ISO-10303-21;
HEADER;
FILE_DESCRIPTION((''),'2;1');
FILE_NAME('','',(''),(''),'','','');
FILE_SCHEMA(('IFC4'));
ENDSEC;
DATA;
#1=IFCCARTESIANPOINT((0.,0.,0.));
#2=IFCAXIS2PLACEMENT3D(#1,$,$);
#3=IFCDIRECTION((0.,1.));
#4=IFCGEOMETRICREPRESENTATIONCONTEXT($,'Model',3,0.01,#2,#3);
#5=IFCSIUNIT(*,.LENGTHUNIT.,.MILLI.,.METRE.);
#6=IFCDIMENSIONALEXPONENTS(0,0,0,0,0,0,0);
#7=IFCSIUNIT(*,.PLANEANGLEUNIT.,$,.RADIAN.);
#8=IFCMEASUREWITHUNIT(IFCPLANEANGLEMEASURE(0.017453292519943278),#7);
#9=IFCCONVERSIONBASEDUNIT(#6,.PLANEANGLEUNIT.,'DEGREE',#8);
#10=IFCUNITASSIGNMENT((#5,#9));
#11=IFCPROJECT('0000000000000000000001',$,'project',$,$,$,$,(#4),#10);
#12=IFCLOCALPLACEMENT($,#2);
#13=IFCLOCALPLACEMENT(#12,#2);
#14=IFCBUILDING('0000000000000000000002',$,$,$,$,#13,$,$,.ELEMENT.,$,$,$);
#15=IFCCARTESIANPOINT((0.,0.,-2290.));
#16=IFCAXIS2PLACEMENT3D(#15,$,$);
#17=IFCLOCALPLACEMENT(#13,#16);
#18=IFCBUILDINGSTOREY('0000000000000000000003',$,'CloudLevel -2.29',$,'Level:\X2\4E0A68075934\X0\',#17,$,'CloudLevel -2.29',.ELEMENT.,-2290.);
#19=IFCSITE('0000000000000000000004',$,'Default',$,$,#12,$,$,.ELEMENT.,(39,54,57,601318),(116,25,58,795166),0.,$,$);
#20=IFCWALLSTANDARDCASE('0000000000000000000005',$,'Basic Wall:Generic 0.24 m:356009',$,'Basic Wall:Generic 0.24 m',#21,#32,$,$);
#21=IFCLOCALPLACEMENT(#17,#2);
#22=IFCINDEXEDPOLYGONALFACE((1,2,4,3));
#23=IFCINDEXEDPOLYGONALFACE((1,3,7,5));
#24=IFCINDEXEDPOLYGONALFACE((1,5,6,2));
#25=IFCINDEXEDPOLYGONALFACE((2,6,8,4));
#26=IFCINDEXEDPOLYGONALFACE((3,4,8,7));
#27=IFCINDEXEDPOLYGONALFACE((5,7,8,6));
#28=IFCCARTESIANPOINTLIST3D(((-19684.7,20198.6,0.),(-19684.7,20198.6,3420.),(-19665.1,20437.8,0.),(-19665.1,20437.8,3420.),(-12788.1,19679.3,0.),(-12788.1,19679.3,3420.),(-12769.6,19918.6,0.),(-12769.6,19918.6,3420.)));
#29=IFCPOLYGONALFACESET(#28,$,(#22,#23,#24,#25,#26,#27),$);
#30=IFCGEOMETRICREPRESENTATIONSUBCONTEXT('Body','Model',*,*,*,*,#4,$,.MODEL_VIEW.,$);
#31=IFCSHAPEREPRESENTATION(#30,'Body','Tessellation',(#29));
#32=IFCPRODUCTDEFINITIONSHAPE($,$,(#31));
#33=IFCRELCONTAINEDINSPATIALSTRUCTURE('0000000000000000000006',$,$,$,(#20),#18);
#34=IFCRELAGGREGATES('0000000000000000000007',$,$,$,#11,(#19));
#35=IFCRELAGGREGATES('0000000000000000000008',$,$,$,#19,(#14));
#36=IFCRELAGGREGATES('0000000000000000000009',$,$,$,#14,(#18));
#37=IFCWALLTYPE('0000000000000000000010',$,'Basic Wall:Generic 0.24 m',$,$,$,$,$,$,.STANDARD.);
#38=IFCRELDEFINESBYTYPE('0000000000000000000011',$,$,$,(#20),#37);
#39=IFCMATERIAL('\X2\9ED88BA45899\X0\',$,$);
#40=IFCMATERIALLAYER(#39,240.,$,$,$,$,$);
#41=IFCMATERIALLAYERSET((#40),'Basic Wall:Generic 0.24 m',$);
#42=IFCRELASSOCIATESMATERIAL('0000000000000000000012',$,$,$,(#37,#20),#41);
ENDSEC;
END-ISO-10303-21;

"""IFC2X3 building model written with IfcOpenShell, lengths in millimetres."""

from ifc_helpers import new_model, entity, si_unit, converted_unit, direction, frame, origin, place, context, subcontext, project, spatial, polyline, outline, extrude, material, layer, layer_set, layer_usage, type_object, element, save


model = new_model("IFC2X3")

# Units and contexts
model_context = context("Model", 3, precision=0.01, world=origin(), true_north=direction((0.0, 1.0)))
body_context = subcontext(model_context, "Body", "Model", "MODEL_VIEW")
ifc_project = project(units=[si_unit("LENGTHUNIT", "METRE", prefix="MILLI"), converted_unit("PLANEANGLEUNIT", "DEGREE", entity("IfcPlaneAngleMeasure", 0.017453292519943278), si_unit("PLANEANGLEUNIT", "RADIAN"), dimensions=[0, 0, 0, 0, 0, 0, 0])], contexts=[model_context])

# Site, building, storey
site_placement = place(None, origin())
site = spatial("IfcSite", under=ifc_project, at=site_placement, Name="Default", CompositionType="ELEMENT", RefLatitude=(39, 54, 57, 601318), RefLongitude=(116, 25, 58, 795166), RefElevation=0.0)
building_placement = place(site_placement, origin())
building = spatial("IfcBuilding", under=site, at=building_placement, CompositionType="ELEMENT")
storey_placement = place(building_placement, frame((0.0, 0.0, -2290.0)))
storey = spatial("IfcBuildingStorey", under=building, at=storey_placement, Name="CloudLevel -2.29", ObjectType="Level:上标头", LongName="CloudLevel -2.29", CompositionType="ELEMENT", Elevation=-2290.0)

# Shared definitions
ifc_material_1 = material(Name="默认墙")
ifc_layer = layer(ifc_material_1, 240.0)
ifc_layer_set = layer_set([ifc_layer], Name="Basic Wall:Generic 0.24 m")
ifc_layer_usage = layer_usage(ifc_layer_set, "AXIS2", "NEGATIVE", 120.0)
wall_type = type_object("IfcWallType", Name="Basic Wall:Generic 0.24 m", PredefinedType="STANDARD", material=ifc_layer_set)

# Wall
wall_1_placement = place(storey_placement, frame((-19675.7, 20318.3, 0.0), z_axis=(0.0, 0.0, 1.0), x_axis=(0.997177, -0.075088, 0.0)))
element("IfcWallStandardCase", 1, at=wall_1_placement, inside=storey, type_object=wall_type, material=ifc_layer_usage, Name="Basic Wall:Generic 0.24 m:356009", ObjectType="Basic Wall:Generic 0.24 m", context=body_context, shape_type="SweptSolid", body=[
    extrude(outline(polyline([(6916.2, -120.0), (6916.6, 120.0), (1.6, 120.0), (0.0, -120.0), (6916.2, -120.0)])), origin(), (0.0, 0.0, 1.0), 3420.0),
])

save(model, "model.ifc")
